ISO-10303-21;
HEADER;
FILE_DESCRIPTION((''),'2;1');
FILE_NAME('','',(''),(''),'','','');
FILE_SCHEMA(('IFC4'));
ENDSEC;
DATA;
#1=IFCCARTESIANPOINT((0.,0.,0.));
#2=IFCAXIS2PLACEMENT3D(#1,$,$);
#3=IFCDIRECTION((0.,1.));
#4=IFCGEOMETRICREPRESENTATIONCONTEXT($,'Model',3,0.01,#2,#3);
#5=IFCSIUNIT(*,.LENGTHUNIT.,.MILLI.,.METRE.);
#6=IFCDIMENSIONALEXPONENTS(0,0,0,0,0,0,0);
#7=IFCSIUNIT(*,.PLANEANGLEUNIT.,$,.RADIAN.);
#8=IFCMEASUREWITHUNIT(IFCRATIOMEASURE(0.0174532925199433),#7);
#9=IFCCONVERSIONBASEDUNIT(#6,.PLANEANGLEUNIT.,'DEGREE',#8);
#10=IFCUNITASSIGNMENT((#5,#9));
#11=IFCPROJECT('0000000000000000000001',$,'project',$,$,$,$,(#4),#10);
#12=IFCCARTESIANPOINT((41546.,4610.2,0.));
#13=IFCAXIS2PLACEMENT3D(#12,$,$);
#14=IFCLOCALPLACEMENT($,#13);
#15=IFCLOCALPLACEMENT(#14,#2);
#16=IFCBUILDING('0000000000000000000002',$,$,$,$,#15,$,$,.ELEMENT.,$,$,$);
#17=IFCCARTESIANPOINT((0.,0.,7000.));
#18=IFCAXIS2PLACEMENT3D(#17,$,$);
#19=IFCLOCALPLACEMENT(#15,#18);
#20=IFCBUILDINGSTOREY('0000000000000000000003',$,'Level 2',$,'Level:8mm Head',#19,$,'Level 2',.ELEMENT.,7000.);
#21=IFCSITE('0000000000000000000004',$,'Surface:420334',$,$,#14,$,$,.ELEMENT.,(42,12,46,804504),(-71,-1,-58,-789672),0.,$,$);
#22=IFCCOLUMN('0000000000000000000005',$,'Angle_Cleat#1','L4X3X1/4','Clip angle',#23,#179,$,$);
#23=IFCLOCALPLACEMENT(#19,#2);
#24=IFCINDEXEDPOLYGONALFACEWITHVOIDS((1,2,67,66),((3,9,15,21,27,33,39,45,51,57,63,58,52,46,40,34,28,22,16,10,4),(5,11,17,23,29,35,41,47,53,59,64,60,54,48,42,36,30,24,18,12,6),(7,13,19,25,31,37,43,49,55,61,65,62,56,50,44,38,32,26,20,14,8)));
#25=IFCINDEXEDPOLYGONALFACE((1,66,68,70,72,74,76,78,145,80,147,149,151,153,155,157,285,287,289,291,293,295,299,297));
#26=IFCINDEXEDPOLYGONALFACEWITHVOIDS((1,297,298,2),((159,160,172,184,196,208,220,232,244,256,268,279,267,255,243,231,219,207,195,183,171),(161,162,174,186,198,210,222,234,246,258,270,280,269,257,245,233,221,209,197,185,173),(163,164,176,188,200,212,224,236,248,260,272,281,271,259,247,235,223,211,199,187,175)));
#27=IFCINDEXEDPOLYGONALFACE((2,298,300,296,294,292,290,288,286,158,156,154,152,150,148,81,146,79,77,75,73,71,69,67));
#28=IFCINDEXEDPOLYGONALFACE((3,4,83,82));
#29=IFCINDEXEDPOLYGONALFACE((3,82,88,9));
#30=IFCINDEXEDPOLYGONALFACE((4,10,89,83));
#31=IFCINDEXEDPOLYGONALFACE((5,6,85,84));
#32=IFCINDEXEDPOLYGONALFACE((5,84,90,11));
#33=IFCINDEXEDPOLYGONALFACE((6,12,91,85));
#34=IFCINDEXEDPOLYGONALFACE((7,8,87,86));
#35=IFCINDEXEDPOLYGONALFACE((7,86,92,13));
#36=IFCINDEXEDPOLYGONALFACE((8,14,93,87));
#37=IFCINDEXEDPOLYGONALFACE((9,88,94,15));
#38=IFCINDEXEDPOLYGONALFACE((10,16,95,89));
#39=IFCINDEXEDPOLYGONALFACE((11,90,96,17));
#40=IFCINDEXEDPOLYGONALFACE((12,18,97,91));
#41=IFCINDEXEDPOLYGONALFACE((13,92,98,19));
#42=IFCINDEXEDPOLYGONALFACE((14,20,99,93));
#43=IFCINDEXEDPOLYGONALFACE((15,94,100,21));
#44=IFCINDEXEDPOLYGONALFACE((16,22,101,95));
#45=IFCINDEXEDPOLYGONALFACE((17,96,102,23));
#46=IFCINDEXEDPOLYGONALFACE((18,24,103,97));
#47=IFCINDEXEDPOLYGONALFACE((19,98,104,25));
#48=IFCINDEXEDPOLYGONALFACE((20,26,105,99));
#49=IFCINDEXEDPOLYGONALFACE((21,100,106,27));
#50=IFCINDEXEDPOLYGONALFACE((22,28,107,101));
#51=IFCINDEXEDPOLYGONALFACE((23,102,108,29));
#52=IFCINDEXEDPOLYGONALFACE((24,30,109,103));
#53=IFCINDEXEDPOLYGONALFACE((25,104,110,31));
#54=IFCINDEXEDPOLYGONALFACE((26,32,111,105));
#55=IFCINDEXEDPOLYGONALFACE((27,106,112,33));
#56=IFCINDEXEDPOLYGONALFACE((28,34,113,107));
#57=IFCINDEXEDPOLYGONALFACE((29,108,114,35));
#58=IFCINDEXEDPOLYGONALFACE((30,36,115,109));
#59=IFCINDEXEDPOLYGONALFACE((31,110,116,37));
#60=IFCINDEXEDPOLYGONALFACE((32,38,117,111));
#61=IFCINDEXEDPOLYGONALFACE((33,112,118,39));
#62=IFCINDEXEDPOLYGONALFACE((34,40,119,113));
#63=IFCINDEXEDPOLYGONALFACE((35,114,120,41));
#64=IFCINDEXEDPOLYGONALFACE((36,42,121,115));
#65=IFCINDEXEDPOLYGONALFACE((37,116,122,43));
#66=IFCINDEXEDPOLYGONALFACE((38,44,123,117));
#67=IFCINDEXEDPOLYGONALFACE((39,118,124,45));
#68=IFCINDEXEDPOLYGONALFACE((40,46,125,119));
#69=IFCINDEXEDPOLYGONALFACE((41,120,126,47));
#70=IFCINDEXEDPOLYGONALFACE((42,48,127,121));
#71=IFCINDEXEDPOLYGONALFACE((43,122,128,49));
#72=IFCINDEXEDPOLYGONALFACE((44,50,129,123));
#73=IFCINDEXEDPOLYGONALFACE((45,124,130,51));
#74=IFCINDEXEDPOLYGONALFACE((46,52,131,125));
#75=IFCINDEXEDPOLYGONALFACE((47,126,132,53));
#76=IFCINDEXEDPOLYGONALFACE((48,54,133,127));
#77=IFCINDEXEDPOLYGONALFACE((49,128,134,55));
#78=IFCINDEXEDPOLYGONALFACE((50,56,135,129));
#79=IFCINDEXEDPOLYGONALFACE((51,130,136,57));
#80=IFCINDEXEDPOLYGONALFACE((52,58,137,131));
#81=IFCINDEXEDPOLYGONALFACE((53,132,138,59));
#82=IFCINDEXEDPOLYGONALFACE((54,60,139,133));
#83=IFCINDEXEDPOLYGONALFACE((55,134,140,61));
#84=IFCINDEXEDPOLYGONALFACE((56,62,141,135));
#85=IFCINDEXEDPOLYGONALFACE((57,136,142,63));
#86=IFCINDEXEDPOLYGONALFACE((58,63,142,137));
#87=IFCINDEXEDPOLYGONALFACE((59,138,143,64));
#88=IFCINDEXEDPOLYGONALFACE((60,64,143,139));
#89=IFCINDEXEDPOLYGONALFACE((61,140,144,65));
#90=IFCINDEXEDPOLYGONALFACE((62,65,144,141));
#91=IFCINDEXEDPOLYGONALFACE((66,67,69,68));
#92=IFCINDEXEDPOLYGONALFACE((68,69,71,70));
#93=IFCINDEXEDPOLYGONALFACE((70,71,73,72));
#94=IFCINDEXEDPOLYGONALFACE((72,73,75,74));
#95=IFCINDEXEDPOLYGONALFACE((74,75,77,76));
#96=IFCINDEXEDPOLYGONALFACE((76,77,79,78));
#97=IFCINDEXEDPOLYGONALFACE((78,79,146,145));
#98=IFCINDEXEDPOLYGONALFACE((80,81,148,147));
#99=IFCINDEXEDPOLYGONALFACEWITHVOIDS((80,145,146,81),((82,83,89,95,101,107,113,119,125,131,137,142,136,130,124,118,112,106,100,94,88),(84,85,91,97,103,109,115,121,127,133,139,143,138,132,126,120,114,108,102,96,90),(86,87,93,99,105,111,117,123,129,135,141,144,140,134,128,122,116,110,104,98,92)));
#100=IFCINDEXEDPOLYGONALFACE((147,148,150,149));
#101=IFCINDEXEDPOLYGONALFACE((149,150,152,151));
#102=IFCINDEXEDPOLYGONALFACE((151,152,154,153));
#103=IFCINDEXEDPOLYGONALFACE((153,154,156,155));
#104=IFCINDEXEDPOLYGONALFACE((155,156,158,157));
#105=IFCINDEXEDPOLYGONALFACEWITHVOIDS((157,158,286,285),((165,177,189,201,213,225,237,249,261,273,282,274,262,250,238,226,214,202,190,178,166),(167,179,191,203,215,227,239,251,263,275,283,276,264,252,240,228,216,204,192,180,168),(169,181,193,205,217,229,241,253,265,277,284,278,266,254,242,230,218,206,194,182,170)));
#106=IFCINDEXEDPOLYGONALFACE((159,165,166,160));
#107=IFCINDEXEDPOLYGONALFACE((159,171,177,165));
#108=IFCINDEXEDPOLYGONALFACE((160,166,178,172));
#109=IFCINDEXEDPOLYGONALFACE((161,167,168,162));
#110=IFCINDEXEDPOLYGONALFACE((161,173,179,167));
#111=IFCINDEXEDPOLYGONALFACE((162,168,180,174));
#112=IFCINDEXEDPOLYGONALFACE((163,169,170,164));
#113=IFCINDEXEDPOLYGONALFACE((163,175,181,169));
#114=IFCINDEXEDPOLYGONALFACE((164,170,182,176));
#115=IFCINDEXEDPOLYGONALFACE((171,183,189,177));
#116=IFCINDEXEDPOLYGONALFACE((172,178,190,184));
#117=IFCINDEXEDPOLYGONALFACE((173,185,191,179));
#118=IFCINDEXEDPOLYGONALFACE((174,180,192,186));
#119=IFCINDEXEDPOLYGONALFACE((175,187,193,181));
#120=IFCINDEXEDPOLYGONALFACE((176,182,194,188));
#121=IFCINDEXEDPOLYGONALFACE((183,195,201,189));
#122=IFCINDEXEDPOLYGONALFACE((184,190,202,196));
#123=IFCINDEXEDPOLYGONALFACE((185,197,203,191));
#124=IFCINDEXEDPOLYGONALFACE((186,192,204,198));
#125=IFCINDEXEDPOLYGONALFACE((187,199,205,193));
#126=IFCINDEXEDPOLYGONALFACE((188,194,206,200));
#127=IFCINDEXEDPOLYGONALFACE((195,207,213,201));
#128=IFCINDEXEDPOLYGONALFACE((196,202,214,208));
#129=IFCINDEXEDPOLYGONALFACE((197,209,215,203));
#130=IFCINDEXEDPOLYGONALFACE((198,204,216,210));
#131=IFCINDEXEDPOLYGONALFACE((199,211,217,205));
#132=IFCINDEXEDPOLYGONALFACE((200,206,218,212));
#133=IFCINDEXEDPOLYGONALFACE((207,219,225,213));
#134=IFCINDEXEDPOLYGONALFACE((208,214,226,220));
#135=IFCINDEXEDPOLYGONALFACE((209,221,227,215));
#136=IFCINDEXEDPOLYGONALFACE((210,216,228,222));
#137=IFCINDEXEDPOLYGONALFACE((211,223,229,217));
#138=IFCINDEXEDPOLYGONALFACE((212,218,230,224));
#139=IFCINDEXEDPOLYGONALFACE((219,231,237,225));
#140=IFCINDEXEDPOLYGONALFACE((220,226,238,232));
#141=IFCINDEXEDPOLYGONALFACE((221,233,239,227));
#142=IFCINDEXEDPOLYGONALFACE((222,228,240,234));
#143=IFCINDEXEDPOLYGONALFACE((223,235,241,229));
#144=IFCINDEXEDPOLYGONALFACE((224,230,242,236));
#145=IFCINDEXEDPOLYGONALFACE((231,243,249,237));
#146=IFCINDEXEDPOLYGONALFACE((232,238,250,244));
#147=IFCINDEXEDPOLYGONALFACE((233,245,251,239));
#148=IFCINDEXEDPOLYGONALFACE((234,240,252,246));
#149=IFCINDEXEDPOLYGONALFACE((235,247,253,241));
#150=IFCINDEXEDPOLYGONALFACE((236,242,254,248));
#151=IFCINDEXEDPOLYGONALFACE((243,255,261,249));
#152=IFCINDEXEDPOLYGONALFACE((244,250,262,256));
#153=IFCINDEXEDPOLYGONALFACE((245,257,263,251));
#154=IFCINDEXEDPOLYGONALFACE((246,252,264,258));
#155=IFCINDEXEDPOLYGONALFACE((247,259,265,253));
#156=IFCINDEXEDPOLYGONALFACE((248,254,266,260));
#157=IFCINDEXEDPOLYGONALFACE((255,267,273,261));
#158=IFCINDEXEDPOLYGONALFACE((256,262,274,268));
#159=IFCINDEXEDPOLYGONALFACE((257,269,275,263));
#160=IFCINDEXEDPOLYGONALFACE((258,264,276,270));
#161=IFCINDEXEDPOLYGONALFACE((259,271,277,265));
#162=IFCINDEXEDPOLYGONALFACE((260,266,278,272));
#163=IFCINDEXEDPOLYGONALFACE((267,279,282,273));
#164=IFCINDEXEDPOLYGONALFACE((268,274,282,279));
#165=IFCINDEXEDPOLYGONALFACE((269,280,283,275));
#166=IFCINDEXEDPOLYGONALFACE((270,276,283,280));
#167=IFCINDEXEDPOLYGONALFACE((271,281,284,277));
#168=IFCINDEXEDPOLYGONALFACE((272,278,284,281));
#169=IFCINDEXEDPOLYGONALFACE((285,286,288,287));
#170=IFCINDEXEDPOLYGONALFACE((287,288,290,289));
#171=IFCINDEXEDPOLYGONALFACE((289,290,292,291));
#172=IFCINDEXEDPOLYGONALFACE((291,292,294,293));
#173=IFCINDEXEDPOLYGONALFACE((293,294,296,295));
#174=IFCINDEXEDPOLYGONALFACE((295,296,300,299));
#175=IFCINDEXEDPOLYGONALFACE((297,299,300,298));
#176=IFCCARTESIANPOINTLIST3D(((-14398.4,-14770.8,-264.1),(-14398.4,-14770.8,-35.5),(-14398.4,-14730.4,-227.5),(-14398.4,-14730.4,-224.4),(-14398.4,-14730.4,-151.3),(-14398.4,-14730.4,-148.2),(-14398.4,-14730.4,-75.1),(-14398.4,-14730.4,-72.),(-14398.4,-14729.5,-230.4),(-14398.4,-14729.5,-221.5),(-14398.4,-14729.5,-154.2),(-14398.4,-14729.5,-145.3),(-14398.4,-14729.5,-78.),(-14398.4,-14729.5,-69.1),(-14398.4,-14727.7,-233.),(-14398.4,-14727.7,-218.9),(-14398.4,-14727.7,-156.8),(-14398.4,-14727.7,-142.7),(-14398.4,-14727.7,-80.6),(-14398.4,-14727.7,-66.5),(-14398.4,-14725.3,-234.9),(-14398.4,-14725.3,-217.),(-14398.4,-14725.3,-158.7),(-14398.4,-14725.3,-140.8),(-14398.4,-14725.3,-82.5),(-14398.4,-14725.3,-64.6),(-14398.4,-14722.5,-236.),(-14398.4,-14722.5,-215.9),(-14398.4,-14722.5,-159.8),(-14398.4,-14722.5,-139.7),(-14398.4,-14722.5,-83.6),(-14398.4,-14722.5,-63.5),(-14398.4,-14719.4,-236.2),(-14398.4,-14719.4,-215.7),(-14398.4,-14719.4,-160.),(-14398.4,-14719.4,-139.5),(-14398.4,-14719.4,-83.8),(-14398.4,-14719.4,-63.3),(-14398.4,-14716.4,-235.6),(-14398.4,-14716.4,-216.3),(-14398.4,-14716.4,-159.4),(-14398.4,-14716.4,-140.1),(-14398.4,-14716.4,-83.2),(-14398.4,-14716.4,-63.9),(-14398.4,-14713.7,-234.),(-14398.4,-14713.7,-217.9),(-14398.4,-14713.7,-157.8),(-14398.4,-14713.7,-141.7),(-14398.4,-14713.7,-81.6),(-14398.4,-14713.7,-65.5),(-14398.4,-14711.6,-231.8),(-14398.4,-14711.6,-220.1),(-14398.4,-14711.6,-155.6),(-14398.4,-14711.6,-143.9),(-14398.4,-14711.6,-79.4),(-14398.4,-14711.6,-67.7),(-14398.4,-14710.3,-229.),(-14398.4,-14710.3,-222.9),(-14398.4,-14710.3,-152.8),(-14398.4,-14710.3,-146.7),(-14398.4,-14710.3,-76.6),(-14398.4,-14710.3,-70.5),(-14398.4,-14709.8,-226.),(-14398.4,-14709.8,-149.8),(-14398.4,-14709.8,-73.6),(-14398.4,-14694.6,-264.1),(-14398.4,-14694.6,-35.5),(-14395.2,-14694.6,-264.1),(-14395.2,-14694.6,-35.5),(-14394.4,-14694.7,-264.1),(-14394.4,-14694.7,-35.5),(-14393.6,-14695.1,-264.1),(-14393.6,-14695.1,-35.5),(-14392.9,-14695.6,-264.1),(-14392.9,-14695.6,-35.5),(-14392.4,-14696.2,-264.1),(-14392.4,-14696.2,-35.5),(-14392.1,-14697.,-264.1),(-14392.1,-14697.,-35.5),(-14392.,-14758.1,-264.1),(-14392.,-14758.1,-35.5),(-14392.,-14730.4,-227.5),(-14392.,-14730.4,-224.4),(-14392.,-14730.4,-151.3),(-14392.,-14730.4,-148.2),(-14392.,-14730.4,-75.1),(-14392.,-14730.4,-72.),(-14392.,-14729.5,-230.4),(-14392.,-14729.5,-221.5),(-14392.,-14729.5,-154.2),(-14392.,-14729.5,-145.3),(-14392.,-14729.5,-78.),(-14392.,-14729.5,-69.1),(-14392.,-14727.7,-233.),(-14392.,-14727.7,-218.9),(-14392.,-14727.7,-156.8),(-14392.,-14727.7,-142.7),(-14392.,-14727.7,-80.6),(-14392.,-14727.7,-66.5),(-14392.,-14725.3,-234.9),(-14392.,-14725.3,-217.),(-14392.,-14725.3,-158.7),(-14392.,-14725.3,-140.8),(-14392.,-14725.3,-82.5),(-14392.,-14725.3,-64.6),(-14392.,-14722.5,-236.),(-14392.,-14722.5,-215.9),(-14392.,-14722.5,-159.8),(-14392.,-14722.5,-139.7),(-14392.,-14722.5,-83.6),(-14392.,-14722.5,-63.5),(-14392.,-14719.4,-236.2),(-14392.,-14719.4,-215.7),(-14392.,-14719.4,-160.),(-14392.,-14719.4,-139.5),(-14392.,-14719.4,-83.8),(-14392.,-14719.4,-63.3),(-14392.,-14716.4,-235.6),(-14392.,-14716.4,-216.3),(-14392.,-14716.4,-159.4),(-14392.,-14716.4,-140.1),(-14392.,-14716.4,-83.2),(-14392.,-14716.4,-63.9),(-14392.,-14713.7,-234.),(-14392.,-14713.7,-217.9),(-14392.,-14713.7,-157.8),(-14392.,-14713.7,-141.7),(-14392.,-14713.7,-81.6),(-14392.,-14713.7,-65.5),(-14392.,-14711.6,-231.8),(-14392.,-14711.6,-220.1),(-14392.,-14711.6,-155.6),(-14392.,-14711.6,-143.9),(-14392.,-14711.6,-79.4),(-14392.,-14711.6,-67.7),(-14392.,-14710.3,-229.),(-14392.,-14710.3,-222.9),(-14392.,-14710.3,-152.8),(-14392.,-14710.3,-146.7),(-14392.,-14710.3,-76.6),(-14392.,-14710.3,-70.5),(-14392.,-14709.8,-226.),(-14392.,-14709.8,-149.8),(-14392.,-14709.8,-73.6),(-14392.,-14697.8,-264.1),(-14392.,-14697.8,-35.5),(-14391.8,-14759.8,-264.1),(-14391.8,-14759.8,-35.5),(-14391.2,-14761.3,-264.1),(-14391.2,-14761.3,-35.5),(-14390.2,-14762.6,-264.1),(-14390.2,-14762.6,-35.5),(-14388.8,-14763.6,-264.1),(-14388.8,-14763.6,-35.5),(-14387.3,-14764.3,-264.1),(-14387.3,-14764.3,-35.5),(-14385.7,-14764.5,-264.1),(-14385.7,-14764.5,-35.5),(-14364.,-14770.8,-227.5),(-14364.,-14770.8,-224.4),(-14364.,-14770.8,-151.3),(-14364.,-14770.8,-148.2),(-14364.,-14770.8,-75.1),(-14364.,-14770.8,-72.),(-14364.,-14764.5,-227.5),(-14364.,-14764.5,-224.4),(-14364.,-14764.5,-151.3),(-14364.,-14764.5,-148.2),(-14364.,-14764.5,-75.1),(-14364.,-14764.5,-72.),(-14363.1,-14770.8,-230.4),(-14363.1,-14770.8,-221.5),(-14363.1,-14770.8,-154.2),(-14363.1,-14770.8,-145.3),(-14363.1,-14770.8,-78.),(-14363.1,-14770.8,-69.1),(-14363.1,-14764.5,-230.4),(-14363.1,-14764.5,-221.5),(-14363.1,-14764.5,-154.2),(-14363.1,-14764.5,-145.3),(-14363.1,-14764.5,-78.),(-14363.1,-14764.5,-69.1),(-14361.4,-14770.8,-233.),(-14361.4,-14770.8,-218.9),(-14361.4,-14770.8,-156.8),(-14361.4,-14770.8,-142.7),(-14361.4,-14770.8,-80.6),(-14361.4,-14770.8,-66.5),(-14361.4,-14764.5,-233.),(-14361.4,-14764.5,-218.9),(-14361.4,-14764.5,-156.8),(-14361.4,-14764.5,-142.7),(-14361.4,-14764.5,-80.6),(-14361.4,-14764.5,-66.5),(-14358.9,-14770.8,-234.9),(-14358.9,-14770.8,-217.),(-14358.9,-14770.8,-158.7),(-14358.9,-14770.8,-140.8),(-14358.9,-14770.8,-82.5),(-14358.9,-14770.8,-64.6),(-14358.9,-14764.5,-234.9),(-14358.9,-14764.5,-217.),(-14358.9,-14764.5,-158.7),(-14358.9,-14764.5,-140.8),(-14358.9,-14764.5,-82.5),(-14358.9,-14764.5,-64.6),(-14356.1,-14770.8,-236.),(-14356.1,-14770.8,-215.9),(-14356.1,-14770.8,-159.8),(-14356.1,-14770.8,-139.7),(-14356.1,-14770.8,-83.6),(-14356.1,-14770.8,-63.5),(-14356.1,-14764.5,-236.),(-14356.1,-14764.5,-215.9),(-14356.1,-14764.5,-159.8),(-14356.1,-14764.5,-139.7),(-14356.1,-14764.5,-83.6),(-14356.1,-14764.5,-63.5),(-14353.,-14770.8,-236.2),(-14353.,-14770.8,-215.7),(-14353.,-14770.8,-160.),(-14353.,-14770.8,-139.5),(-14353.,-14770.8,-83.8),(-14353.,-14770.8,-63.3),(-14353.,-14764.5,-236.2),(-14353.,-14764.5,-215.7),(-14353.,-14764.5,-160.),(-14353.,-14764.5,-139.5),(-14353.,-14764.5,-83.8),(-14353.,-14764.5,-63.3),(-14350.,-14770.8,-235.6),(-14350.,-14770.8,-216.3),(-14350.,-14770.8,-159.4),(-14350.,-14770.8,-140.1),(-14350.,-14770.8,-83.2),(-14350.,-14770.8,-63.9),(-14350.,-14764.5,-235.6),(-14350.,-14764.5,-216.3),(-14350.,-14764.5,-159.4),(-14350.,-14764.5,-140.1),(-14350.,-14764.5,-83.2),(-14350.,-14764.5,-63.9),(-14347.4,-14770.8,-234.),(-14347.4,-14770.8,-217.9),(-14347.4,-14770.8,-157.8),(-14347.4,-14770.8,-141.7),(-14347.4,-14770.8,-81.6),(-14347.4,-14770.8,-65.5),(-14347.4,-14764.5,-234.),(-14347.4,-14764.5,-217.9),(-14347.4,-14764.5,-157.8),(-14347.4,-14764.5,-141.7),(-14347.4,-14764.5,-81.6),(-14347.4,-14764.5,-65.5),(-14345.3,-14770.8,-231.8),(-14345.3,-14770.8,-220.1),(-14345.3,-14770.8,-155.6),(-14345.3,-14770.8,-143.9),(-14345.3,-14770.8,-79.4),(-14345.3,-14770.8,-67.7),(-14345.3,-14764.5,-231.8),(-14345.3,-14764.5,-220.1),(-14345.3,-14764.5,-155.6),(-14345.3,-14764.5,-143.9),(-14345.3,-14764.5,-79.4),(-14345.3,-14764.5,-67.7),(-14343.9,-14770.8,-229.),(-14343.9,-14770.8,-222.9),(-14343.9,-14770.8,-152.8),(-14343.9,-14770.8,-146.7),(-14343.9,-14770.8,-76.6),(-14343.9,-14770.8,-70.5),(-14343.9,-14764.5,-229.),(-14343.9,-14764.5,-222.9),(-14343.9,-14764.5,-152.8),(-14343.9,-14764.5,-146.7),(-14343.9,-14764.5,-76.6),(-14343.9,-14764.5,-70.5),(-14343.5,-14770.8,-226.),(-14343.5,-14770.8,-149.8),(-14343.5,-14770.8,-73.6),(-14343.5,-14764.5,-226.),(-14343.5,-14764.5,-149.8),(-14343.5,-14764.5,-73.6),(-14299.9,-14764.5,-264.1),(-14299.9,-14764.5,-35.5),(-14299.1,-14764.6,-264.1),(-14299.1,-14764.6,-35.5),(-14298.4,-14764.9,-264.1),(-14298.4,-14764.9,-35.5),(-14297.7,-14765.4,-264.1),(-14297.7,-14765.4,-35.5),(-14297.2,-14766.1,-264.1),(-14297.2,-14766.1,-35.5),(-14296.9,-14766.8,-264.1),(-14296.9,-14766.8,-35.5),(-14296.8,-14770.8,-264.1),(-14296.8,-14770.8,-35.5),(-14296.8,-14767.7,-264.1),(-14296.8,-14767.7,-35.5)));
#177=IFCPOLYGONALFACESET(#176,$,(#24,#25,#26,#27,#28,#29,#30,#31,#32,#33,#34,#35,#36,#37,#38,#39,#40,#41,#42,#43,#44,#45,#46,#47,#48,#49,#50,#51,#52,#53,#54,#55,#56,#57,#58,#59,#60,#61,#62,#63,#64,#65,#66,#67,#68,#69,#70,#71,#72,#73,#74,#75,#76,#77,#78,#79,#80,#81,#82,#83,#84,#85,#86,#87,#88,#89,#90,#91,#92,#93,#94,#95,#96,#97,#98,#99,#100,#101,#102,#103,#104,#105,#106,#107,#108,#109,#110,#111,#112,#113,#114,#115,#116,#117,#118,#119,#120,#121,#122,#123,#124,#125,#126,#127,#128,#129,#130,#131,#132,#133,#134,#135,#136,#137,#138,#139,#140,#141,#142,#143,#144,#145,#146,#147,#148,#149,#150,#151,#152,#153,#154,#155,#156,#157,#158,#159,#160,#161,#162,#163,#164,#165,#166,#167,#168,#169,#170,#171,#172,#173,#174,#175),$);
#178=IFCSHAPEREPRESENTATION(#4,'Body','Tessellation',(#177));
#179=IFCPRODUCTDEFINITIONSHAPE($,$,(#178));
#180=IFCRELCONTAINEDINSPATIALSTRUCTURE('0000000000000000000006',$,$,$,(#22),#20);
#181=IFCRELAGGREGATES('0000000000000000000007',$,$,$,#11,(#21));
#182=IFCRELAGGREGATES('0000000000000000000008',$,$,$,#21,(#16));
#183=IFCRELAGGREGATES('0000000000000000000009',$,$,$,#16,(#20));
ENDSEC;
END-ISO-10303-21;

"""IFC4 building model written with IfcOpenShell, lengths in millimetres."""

from ifc_helpers import new_model, entity, si_unit, converted_unit, direction, frame, frame_2d, origin, origin_2d_with_axis, place, context, project, spatial, circle, l_section, extrude, element, save


model = new_model("IFC4")

# Units and contexts
model_context = context("Model", 3, precision=0.01, world=origin(), true_north=direction((0.0, 1.0)))
ifc_project = project(units=[si_unit("LENGTHUNIT", "METRE", prefix="MILLI"), converted_unit("PLANEANGLEUNIT", "DEGREE", entity("IfcRatioMeasure", 0.0174532925199433), si_unit("PLANEANGLEUNIT", "RADIAN"), dimensions=[0, 0, 0, 0, 0, 0, 0])], contexts=[model_context])

# Site, building, storey
site_placement = place(None, frame((41546.0, 4610.2, 0.0)))
site = spatial("IfcSite", under=ifc_project, at=site_placement, Name="Surface:420334", CompositionType="ELEMENT", RefLatitude=(42, 12, 46, 804504), RefLongitude=(-71, -1, -58, -789672), RefElevation=0.0)
building_placement = place(site_placement, origin())
building = spatial("IfcBuilding", under=site, at=building_placement, CompositionType="ELEMENT")
storey_placement = place(building_placement, frame((0.0, 0.0, 7000.0)))
storey = spatial("IfcBuildingStorey", under=building, at=storey_placement, Name="Level 2", ObjectType="Level:8mm Head", LongName="Level 2", CompositionType="ELEMENT", Elevation=7000.0)

# Column, openings
column_1_placement = place(storey_placement, frame((-14367.2, -14752.5, -264.1), z_axis=(0.0, 0.0, -1.0), x_axis=(0.0, 1.0, 0.0)))
column_1 = element("IfcColumn", 1, at=column_1_placement, inside=storey, Name="Angle_Cleat#1", Description="L4X3X1/4", ObjectType="Clip angle", context=model_context, shape_type="SweptSolid", body=[
    extrude(l_section(Depth=101.6, Width=76.2, Thickness=6.3, FilletRadius=6.3, EdgeRadius=3.2, at=frame_2d((19.8, 19.7))), origin(), (0.0, 0.0, -1.0), 228.6),
])
opening_1_placement = place(column_1_placement, frame((32.4, -31.5, -114.3), z_axis=(0.0, 1.0, 0.0), x_axis=(1.0, 0.0, 0.0)))
element("IfcOpeningElement", 2, at=opening_1_placement, cuts=column_1, ObjectType="Opening", context=model_context, shape_type="SweptSolid", body=[
    extrude(circle(Radius=10.3, at=origin_2d_with_axis()), origin(), (0.0, 0.0, 1.0), 7.3),
])
opening_2_placement = place(column_1_placement, frame((32.4, -31.5, -114.3), z_axis=(0.0, 1.0, 0.0), x_axis=(1.0, 0.0, 0.0)))
element("IfcOpeningElement", 3, at=opening_2_placement, cuts=column_1, ObjectType="Opening", context=model_context, shape_type="SweptSolid", body=[
    extrude(circle(Radius=10.3, at=frame_2d((0.0, 76.2), x_axis=(1.0, 0.0))), origin(), (0.0, 0.0, 1.0), 7.3),
])
opening_3_placement = place(column_1_placement, frame((32.4, -31.5, -114.3), z_axis=(0.0, 1.0, 0.0), x_axis=(1.0, 0.0, 0.0)))
element("IfcOpeningElement", 4, at=opening_3_placement, cuts=column_1, ObjectType="Opening", context=model_context, shape_type="SweptSolid", body=[
    extrude(circle(Radius=10.3, at=frame_2d((0.0, -76.2), x_axis=(1.0, 0.0))), origin(), (0.0, 0.0, 1.0), 7.3),
])
opening_4_placement = place(column_1_placement, frame((-18.9, 13.5, -114.3), z_axis=(1.0, 0.0, 0.0), x_axis=(0.0, 1.0, 0.0)))
element("IfcOpeningElement", 5, at=opening_4_placement, cuts=column_1, ObjectType="Opening", context=model_context, shape_type="SweptSolid", body=[
    extrude(circle(Radius=10.3, at=origin_2d_with_axis()), origin(), (0.0, 0.0, 1.0), 7.3),
])
opening_5_placement = place(column_1_placement, frame((-18.9, 13.5, -114.3), z_axis=(1.0, 0.0, 0.0), x_axis=(0.0, 1.0, 0.0)))
element("IfcOpeningElement", 6, at=opening_5_placement, cuts=column_1, ObjectType="Opening", context=model_context, shape_type="SweptSolid", body=[
    extrude(circle(Radius=10.3, at=frame_2d((0.0, 76.2), x_axis=(1.0, 0.0))), origin(), (0.0, 0.0, 1.0), 7.3),
])
opening_6_placement = place(column_1_placement, frame((-18.9, 13.5, -114.3), z_axis=(1.0, 0.0, 0.0), x_axis=(0.0, 1.0, 0.0)))
element("IfcOpeningElement", 7, at=opening_6_placement, cuts=column_1, ObjectType="Opening", context=model_context, shape_type="SweptSolid", body=[
    extrude(circle(Radius=10.3, at=frame_2d((0.0, -76.2), x_axis=(1.0, 0.0))), origin(), (0.0, 0.0, 1.0), 7.3),
])

save(model, "model.ifc")
